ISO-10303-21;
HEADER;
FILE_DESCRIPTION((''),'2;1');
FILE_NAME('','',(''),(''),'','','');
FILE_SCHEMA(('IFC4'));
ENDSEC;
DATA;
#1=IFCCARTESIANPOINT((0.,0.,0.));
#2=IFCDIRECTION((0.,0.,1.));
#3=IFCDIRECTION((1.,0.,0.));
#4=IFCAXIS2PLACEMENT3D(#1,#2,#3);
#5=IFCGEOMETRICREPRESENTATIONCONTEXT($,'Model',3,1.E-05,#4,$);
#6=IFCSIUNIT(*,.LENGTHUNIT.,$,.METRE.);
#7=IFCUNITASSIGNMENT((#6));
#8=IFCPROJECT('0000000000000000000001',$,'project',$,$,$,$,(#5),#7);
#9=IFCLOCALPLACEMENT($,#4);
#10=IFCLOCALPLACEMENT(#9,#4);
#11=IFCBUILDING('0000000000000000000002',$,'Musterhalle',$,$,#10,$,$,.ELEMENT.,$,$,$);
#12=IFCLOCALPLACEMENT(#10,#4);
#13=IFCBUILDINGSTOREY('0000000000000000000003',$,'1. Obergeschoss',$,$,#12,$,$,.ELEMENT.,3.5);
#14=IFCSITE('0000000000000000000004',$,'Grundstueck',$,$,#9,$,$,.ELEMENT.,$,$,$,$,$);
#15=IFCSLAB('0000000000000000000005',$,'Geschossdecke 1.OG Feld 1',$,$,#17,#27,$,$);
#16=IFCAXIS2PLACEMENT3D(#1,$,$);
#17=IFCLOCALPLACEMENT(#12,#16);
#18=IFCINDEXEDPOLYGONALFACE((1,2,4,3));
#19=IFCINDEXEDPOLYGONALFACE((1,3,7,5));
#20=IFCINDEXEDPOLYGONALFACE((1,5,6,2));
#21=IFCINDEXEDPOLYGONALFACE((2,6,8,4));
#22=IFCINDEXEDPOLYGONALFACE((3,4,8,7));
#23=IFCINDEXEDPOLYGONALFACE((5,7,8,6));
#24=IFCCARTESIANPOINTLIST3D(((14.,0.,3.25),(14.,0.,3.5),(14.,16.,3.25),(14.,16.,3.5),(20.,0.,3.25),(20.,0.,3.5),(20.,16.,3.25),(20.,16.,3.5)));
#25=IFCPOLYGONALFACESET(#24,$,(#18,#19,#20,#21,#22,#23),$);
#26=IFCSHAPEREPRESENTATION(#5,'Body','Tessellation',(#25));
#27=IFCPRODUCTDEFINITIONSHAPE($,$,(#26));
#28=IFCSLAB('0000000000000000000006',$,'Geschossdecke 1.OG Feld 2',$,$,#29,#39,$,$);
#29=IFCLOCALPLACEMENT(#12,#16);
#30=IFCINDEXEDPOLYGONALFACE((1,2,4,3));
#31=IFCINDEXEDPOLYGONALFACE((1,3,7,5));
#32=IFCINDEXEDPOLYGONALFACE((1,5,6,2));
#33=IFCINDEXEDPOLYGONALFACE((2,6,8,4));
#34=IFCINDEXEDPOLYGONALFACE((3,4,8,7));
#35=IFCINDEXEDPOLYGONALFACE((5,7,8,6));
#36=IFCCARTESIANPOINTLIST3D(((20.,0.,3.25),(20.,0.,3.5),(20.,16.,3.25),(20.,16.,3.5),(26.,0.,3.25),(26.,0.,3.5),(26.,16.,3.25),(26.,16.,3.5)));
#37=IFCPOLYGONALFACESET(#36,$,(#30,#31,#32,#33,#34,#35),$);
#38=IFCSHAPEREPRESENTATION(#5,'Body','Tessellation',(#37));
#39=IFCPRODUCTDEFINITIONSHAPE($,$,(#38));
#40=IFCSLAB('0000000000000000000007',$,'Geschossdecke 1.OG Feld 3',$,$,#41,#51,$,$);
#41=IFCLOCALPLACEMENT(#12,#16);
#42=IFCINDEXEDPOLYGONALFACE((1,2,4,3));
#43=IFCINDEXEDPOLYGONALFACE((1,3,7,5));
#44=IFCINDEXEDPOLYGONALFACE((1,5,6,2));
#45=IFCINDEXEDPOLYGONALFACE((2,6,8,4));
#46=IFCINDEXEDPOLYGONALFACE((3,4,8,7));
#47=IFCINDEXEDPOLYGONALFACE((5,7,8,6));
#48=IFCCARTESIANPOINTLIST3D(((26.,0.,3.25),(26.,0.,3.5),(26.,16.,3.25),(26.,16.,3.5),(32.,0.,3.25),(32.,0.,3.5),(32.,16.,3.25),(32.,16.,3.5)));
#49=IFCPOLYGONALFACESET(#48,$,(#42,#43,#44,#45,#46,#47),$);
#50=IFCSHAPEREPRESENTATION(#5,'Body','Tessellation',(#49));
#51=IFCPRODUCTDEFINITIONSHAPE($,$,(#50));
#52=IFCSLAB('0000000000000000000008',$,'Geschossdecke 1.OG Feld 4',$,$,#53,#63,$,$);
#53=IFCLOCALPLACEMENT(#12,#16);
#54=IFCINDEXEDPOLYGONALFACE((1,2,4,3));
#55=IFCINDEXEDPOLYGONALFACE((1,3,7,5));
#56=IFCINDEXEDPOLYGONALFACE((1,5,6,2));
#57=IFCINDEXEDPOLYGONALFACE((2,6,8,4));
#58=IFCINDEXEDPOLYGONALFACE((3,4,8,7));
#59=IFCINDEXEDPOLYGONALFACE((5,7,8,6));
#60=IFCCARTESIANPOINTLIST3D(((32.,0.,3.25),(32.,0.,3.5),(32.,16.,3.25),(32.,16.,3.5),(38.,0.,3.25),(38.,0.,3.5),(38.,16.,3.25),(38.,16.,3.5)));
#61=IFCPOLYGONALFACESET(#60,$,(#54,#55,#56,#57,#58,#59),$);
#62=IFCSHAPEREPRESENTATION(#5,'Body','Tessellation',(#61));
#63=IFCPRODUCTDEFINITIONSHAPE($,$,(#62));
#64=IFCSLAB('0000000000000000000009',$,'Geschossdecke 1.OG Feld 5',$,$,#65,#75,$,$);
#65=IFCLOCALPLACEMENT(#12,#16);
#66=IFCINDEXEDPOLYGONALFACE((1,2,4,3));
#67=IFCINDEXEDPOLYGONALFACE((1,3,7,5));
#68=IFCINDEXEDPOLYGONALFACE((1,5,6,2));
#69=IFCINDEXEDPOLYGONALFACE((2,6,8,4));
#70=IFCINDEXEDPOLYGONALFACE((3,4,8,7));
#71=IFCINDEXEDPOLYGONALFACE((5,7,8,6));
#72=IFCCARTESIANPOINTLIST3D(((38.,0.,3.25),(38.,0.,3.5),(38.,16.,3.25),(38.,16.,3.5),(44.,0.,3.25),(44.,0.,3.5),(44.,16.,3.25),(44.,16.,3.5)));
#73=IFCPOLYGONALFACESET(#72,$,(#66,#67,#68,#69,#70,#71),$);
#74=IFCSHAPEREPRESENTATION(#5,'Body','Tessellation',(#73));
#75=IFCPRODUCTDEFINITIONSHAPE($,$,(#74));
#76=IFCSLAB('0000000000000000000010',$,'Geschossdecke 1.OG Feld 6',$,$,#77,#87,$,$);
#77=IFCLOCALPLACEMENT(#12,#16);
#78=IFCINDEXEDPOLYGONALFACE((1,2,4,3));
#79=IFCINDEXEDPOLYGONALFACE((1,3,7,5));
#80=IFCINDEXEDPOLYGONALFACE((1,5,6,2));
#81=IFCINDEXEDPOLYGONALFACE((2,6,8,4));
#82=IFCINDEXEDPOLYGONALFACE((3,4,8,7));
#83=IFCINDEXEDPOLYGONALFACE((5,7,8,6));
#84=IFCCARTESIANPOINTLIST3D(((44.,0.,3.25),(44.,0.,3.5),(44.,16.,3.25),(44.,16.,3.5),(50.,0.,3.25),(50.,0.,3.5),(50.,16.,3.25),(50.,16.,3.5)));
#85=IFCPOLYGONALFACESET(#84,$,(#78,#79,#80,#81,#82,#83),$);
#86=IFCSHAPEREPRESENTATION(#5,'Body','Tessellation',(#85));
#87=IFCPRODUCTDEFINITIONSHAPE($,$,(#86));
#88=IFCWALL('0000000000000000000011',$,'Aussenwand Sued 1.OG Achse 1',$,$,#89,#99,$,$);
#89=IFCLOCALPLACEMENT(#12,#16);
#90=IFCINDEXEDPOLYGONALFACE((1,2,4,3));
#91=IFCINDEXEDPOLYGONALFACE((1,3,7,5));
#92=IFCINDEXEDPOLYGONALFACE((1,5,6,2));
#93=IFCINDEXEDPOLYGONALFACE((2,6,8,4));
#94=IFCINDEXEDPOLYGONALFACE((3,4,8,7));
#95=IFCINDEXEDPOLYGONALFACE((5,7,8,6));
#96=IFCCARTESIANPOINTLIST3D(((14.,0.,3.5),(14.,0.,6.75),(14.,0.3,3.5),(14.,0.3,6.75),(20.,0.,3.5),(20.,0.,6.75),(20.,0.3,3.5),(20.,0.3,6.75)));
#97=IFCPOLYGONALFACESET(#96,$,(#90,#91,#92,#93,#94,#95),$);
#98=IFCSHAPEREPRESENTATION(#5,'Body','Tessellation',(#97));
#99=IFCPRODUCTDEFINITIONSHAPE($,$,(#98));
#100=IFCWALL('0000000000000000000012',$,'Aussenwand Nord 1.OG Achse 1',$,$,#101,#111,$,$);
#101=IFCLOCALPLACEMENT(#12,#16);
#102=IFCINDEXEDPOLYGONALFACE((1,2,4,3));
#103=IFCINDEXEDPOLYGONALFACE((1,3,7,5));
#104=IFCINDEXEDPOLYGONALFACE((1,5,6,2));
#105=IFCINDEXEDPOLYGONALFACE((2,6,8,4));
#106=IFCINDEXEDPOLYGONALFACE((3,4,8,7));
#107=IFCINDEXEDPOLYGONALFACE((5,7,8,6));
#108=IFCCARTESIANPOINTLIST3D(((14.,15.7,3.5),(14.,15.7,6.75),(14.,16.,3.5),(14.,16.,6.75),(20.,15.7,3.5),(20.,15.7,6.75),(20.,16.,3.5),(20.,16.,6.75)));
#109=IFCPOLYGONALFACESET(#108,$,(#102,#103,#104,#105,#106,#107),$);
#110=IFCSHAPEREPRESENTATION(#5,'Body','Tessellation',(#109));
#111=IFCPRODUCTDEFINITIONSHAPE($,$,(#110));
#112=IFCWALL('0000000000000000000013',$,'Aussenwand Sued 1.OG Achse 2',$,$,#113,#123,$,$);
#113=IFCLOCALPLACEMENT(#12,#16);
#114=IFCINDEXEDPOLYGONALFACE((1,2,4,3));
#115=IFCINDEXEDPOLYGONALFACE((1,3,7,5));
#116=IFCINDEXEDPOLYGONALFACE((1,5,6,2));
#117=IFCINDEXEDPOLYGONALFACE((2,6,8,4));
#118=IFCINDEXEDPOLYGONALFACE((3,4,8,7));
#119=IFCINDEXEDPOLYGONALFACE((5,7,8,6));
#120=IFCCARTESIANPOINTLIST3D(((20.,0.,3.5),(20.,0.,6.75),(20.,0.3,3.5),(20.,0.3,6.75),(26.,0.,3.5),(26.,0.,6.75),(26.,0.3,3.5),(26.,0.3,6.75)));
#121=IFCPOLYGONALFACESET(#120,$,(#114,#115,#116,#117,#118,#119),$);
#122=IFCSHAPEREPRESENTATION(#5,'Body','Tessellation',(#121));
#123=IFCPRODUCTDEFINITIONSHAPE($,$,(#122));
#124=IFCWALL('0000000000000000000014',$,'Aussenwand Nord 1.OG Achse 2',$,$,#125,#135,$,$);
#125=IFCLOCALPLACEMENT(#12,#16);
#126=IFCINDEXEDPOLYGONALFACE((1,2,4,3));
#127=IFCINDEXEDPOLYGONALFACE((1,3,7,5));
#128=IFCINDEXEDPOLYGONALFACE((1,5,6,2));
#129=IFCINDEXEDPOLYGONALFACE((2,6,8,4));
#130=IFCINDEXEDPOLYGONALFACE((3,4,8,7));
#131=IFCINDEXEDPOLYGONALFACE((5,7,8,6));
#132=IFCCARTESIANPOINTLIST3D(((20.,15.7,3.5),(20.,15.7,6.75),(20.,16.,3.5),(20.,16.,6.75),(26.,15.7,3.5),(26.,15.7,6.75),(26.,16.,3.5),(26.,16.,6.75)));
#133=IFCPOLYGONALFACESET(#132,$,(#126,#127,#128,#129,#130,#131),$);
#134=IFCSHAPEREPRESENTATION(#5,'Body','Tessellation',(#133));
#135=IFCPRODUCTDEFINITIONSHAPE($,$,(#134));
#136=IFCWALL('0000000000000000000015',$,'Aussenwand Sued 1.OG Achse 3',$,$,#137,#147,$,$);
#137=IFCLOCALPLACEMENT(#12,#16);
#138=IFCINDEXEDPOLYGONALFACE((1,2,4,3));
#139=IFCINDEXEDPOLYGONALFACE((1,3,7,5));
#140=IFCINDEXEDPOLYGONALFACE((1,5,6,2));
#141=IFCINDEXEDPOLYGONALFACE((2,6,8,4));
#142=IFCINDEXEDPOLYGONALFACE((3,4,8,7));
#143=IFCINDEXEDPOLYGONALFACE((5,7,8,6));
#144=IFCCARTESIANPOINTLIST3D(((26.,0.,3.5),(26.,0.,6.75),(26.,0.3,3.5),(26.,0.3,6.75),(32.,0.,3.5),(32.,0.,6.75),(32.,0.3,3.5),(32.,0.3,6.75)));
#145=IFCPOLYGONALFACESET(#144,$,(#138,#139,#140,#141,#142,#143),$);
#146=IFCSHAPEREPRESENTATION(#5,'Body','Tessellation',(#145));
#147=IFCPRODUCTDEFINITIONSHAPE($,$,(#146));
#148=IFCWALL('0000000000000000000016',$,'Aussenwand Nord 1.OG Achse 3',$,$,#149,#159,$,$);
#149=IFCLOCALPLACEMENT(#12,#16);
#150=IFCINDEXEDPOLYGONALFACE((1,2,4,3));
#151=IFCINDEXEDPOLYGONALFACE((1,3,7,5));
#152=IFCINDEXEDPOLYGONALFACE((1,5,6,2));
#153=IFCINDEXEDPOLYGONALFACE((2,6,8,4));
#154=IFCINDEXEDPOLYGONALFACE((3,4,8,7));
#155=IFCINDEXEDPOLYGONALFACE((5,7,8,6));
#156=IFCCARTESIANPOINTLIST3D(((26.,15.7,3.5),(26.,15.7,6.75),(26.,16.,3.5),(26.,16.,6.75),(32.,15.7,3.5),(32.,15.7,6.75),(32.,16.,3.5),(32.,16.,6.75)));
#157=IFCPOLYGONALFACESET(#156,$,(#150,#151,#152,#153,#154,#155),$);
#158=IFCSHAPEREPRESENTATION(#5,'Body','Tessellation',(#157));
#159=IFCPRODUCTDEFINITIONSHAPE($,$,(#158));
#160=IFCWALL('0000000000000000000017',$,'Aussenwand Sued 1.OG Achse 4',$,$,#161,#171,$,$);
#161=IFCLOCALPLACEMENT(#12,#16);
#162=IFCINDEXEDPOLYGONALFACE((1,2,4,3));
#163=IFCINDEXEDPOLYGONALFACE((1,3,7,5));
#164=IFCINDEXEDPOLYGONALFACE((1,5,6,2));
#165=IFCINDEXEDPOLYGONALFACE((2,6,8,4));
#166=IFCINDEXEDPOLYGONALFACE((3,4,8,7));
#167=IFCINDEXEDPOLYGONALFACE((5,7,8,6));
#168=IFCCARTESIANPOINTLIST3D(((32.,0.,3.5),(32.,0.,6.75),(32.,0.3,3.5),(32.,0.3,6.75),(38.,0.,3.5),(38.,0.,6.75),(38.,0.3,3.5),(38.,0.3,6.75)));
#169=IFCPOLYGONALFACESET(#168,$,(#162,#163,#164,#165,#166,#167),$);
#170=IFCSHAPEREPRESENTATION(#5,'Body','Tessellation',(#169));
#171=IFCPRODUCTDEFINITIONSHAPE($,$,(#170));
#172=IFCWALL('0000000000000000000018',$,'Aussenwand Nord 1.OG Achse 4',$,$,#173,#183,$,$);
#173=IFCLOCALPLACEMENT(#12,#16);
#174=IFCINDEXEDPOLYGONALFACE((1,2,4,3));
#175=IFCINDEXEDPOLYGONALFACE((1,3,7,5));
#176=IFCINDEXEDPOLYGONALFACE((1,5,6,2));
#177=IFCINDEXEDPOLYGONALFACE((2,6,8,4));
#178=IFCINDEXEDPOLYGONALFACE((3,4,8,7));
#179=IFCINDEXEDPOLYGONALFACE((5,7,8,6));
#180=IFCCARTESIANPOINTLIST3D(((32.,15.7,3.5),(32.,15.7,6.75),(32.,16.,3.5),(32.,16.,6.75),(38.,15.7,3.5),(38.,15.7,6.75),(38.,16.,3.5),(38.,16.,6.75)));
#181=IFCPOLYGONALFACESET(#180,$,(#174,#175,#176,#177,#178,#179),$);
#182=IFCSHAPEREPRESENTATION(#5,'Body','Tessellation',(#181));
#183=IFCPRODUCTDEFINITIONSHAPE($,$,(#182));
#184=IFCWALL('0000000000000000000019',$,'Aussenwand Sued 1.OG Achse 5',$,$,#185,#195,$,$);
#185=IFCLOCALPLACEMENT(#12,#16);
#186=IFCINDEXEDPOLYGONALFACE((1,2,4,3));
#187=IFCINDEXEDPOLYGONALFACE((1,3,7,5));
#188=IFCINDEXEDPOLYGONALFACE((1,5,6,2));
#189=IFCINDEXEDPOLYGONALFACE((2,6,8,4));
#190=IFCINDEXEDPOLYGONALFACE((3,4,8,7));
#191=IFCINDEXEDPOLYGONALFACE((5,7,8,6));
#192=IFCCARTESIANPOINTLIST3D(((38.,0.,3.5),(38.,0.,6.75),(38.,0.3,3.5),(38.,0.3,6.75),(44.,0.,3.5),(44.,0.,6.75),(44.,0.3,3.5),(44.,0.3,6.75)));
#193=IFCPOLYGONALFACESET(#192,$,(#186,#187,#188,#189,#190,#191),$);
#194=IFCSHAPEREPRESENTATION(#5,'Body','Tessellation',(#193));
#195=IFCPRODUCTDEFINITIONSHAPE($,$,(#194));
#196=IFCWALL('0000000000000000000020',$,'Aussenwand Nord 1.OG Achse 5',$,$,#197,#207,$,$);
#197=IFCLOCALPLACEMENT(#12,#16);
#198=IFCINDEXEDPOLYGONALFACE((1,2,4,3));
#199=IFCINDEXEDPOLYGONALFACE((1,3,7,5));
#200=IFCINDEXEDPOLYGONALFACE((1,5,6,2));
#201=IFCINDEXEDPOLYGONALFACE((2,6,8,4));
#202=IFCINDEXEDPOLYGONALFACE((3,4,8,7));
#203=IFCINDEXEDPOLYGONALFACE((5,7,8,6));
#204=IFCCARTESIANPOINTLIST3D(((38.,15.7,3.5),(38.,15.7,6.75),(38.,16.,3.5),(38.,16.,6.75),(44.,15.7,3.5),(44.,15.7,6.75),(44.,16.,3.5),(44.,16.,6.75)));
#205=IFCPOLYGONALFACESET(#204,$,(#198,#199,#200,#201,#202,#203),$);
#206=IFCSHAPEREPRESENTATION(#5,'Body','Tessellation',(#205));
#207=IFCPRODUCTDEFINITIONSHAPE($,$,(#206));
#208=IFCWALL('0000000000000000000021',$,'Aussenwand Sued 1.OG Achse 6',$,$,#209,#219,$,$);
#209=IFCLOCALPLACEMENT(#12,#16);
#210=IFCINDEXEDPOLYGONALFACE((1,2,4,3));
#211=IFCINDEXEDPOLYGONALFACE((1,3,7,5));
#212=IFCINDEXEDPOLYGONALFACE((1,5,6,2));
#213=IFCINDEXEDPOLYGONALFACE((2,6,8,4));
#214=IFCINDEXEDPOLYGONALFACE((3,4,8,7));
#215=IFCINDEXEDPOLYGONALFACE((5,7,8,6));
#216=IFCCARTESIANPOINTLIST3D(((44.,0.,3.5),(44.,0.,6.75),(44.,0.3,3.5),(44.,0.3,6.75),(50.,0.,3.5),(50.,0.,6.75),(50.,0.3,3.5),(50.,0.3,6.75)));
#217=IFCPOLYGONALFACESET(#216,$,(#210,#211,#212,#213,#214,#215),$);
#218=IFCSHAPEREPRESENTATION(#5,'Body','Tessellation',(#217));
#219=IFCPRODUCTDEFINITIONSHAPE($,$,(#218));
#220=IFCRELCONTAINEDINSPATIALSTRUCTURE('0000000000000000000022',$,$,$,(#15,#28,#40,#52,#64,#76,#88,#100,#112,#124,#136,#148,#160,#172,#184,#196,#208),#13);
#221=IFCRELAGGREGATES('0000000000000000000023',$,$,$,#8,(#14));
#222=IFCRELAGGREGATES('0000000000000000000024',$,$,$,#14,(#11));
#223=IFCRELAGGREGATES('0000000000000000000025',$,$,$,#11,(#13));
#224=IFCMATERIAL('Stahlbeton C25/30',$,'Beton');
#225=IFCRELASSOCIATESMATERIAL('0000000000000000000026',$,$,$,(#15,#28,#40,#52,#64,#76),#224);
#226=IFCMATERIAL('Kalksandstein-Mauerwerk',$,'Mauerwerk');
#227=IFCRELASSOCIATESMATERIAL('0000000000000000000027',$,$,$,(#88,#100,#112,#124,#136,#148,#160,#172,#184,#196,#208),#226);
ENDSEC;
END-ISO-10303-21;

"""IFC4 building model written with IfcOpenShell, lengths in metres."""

from ifc_helpers import new_model, si_unit, frame, origin_with_axes, origin_2d, place, context, project, spatial, rectangle, extrude, material, element, save


model = new_model("IFC4")

# Units and contexts
model_context = context("Model", 3, precision=1e-05, world=origin_with_axes())
ifc_project = project(units=[si_unit("LENGTHUNIT", "METRE")], contexts=[model_context])

# Site, building, storey
site_placement = place(None, origin_with_axes())
site = spatial("IfcSite", under=ifc_project, at=site_placement, Name="Grundstueck", CompositionType="ELEMENT")
building_placement = place(site_placement, origin_with_axes())
building = spatial("IfcBuilding", under=site, at=building_placement, Name="Musterhalle", CompositionType="ELEMENT")
storey_placement = place(building_placement, origin_with_axes())
storey = spatial("IfcBuildingStorey", under=building, at=storey_placement, Name="1. Obergeschoss", CompositionType="ELEMENT", Elevation=3.5)

# Slabs
ifc_material_1 = material(Name="Stahlbeton C25/30", Category="Beton")
placement = place(storey_placement, origin_with_axes())
element("IfcSlab", 1, at=placement, inside=storey, material=ifc_material_1, Name="Geschossdecke 1.OG Feld 1", context=model_context, shape_type="SweptSolid", body=[
    extrude(rectangle(XDim=6.0, YDim=16.0, at=origin_2d()), frame((17.0, 8.0, 3.25), z_axis=(0.0, 0.0, 1.0), x_axis=(1.0, 0.0, 0.0)), (0.0, 0.0, 1.0), 0.25),
])
element("IfcSlab", 2, at=placement, inside=storey, material=ifc_material_1, Name="Geschossdecke 1.OG Feld 2", context=model_context, shape_type="SweptSolid", body=[
    extrude(rectangle(XDim=6.0, YDim=16.0, at=origin_2d()), frame((23.0, 8.0, 3.25), z_axis=(0.0, 0.0, 1.0), x_axis=(1.0, 0.0, 0.0)), (0.0, 0.0, 1.0), 0.25),
])
element("IfcSlab", 3, at=placement, inside=storey, material=ifc_material_1, Name="Geschossdecke 1.OG Feld 3", context=model_context, shape_type="SweptSolid", body=[
    extrude(rectangle(XDim=6.0, YDim=16.0, at=origin_2d()), frame((29.0, 8.0, 3.25), z_axis=(0.0, 0.0, 1.0), x_axis=(1.0, 0.0, 0.0)), (0.0, 0.0, 1.0), 0.25),
])
element("IfcSlab", 4, at=placement, inside=storey, material=ifc_material_1, Name="Geschossdecke 1.OG Feld 4", context=model_context, shape_type="SweptSolid", body=[
    extrude(rectangle(XDim=6.0, YDim=16.0, at=origin_2d()), frame((35.0, 8.0, 3.25), z_axis=(0.0, 0.0, 1.0), x_axis=(1.0, 0.0, 0.0)), (0.0, 0.0, 1.0), 0.25),
])
element("IfcSlab", 5, at=placement, inside=storey, material=ifc_material_1, Name="Geschossdecke 1.OG Feld 5", context=model_context, shape_type="SweptSolid", body=[
    extrude(rectangle(XDim=6.0, YDim=16.0, at=origin_2d()), frame((41.0, 8.0, 3.25), z_axis=(0.0, 0.0, 1.0), x_axis=(1.0, 0.0, 0.0)), (0.0, 0.0, 1.0), 0.25),
])
element("IfcSlab", 6, at=placement, inside=storey, material=ifc_material_1, Name="Geschossdecke 1.OG Feld 6", context=model_context, shape_type="SweptSolid", body=[
    extrude(rectangle(XDim=6.0, YDim=16.0, at=origin_2d()), frame((47.0, 8.0, 3.25), z_axis=(0.0, 0.0, 1.0), x_axis=(1.0, 0.0, 0.0)), (0.0, 0.0, 1.0), 0.25),
])

# Walls
ifc_material_2 = material(Name="Kalksandstein-Mauerwerk", Category="Mauerwerk")
element("IfcWall", 7, at=placement, inside=storey, material=ifc_material_2, Name="Aussenwand Sued 1.OG Achse 1", context=model_context, shape_type="SweptSolid", body=[
    extrude(rectangle(XDim=6.0, YDim=0.3, at=origin_2d()), frame((17.0, 0.15, 3.5), z_axis=(0.0, 0.0, 1.0), x_axis=(1.0, 0.0, 0.0)), (0.0, 0.0, 1.0), 3.25),
])
element("IfcWall", 8, at=placement, inside=storey, material=ifc_material_2, Name="Aussenwand Nord 1.OG Achse 1", context=model_context, shape_type="SweptSolid", body=[
    extrude(rectangle(XDim=6.0, YDim=0.3, at=origin_2d()), frame((17.0, 15.85, 3.5), z_axis=(0.0, 0.0, 1.0), x_axis=(1.0, 0.0, 0.0)), (0.0, 0.0, 1.0), 3.25),
])
element("IfcWall", 9, at=placement, inside=storey, material=ifc_material_2, Name="Aussenwand Sued 1.OG Achse 2", context=model_context, shape_type="SweptSolid", body=[
    extrude(rectangle(XDim=6.0, YDim=0.3, at=origin_2d()), frame((23.0, 0.15, 3.5), z_axis=(0.0, 0.0, 1.0), x_axis=(1.0, 0.0, 0.0)), (0.0, 0.0, 1.0), 3.25),
])
element("IfcWall", 10, at=placement, inside=storey, material=ifc_material_2, Name="Aussenwand Nord 1.OG Achse 2", context=model_context, shape_type="SweptSolid", body=[
    extrude(rectangle(XDim=6.0, YDim=0.3, at=origin_2d()), frame((23.0, 15.85, 3.5), z_axis=(0.0, 0.0, 1.0), x_axis=(1.0, 0.0, 0.0)), (0.0, 0.0, 1.0), 3.25),
])
element("IfcWall", 11, at=placement, inside=storey, material=ifc_material_2, Name="Aussenwand Sued 1.OG Achse 3", context=model_context, shape_type="SweptSolid", body=[
    extrude(rectangle(XDim=6.0, YDim=0.3, at=origin_2d()), frame((29.0, 0.15, 3.5), z_axis=(0.0, 0.0, 1.0), x_axis=(1.0, 0.0, 0.0)), (0.0, 0.0, 1.0), 3.25),
])
element("IfcWall", 12, at=placement, inside=storey, material=ifc_material_2, Name="Aussenwand Nord 1.OG Achse 3", context=model_context, shape_type="SweptSolid", body=[
    extrude(rectangle(XDim=6.0, YDim=0.3, at=origin_2d()), frame((29.0, 15.85, 3.5), z_axis=(0.0, 0.0, 1.0), x_axis=(1.0, 0.0, 0.0)), (0.0, 0.0, 1.0), 3.25),
])
element("IfcWall", 13, at=placement, inside=storey, material=ifc_material_2, Name="Aussenwand Sued 1.OG Achse 4", context=model_context, shape_type="SweptSolid", body=[
    extrude(rectangle(XDim=6.0, YDim=0.3, at=origin_2d()), frame((35.0, 0.15, 3.5), z_axis=(0.0, 0.0, 1.0), x_axis=(1.0, 0.0, 0.0)), (0.0, 0.0, 1.0), 3.25),
])
element("IfcWall", 14, at=placement, inside=storey, material=ifc_material_2, Name="Aussenwand Nord 1.OG Achse 4", context=model_context, shape_type="SweptSolid", body=[
    extrude(rectangle(XDim=6.0, YDim=0.3, at=origin_2d()), frame((35.0, 15.85, 3.5), z_axis=(0.0, 0.0, 1.0), x_axis=(1.0, 0.0, 0.0)), (0.0, 0.0, 1.0), 3.25),
])
element("IfcWall", 15, at=placement, inside=storey, material=ifc_material_2, Name="Aussenwand Sued 1.OG Achse 5", context=model_context, shape_type="SweptSolid", body=[
    extrude(rectangle(XDim=6.0, YDim=0.3, at=origin_2d()), frame((41.0, 0.15, 3.5), z_axis=(0.0, 0.0, 1.0), x_axis=(1.0, 0.0, 0.0)), (0.0, 0.0, 1.0), 3.25),
])
element("IfcWall", 16, at=placement, inside=storey, material=ifc_material_2, Name="Aussenwand Nord 1.OG Achse 5", context=model_context, shape_type="SweptSolid", body=[
    extrude(rectangle(XDim=6.0, YDim=0.3, at=origin_2d()), frame((41.0, 15.85, 3.5), z_axis=(0.0, 0.0, 1.0), x_axis=(1.0, 0.0, 0.0)), (0.0, 0.0, 1.0), 3.25),
])
element("IfcWall", 17, at=placement, inside=storey, material=ifc_material_2, Name="Aussenwand Sued 1.OG Achse 6", context=model_context, shape_type="SweptSolid", body=[
    extrude(rectangle(XDim=6.0, YDim=0.3, at=origin_2d()), frame((47.0, 0.15, 3.5), z_axis=(0.0, 0.0, 1.0), x_axis=(1.0, 0.0, 0.0)), (0.0, 0.0, 1.0), 3.25),
])

save(model, "model.ifc")
